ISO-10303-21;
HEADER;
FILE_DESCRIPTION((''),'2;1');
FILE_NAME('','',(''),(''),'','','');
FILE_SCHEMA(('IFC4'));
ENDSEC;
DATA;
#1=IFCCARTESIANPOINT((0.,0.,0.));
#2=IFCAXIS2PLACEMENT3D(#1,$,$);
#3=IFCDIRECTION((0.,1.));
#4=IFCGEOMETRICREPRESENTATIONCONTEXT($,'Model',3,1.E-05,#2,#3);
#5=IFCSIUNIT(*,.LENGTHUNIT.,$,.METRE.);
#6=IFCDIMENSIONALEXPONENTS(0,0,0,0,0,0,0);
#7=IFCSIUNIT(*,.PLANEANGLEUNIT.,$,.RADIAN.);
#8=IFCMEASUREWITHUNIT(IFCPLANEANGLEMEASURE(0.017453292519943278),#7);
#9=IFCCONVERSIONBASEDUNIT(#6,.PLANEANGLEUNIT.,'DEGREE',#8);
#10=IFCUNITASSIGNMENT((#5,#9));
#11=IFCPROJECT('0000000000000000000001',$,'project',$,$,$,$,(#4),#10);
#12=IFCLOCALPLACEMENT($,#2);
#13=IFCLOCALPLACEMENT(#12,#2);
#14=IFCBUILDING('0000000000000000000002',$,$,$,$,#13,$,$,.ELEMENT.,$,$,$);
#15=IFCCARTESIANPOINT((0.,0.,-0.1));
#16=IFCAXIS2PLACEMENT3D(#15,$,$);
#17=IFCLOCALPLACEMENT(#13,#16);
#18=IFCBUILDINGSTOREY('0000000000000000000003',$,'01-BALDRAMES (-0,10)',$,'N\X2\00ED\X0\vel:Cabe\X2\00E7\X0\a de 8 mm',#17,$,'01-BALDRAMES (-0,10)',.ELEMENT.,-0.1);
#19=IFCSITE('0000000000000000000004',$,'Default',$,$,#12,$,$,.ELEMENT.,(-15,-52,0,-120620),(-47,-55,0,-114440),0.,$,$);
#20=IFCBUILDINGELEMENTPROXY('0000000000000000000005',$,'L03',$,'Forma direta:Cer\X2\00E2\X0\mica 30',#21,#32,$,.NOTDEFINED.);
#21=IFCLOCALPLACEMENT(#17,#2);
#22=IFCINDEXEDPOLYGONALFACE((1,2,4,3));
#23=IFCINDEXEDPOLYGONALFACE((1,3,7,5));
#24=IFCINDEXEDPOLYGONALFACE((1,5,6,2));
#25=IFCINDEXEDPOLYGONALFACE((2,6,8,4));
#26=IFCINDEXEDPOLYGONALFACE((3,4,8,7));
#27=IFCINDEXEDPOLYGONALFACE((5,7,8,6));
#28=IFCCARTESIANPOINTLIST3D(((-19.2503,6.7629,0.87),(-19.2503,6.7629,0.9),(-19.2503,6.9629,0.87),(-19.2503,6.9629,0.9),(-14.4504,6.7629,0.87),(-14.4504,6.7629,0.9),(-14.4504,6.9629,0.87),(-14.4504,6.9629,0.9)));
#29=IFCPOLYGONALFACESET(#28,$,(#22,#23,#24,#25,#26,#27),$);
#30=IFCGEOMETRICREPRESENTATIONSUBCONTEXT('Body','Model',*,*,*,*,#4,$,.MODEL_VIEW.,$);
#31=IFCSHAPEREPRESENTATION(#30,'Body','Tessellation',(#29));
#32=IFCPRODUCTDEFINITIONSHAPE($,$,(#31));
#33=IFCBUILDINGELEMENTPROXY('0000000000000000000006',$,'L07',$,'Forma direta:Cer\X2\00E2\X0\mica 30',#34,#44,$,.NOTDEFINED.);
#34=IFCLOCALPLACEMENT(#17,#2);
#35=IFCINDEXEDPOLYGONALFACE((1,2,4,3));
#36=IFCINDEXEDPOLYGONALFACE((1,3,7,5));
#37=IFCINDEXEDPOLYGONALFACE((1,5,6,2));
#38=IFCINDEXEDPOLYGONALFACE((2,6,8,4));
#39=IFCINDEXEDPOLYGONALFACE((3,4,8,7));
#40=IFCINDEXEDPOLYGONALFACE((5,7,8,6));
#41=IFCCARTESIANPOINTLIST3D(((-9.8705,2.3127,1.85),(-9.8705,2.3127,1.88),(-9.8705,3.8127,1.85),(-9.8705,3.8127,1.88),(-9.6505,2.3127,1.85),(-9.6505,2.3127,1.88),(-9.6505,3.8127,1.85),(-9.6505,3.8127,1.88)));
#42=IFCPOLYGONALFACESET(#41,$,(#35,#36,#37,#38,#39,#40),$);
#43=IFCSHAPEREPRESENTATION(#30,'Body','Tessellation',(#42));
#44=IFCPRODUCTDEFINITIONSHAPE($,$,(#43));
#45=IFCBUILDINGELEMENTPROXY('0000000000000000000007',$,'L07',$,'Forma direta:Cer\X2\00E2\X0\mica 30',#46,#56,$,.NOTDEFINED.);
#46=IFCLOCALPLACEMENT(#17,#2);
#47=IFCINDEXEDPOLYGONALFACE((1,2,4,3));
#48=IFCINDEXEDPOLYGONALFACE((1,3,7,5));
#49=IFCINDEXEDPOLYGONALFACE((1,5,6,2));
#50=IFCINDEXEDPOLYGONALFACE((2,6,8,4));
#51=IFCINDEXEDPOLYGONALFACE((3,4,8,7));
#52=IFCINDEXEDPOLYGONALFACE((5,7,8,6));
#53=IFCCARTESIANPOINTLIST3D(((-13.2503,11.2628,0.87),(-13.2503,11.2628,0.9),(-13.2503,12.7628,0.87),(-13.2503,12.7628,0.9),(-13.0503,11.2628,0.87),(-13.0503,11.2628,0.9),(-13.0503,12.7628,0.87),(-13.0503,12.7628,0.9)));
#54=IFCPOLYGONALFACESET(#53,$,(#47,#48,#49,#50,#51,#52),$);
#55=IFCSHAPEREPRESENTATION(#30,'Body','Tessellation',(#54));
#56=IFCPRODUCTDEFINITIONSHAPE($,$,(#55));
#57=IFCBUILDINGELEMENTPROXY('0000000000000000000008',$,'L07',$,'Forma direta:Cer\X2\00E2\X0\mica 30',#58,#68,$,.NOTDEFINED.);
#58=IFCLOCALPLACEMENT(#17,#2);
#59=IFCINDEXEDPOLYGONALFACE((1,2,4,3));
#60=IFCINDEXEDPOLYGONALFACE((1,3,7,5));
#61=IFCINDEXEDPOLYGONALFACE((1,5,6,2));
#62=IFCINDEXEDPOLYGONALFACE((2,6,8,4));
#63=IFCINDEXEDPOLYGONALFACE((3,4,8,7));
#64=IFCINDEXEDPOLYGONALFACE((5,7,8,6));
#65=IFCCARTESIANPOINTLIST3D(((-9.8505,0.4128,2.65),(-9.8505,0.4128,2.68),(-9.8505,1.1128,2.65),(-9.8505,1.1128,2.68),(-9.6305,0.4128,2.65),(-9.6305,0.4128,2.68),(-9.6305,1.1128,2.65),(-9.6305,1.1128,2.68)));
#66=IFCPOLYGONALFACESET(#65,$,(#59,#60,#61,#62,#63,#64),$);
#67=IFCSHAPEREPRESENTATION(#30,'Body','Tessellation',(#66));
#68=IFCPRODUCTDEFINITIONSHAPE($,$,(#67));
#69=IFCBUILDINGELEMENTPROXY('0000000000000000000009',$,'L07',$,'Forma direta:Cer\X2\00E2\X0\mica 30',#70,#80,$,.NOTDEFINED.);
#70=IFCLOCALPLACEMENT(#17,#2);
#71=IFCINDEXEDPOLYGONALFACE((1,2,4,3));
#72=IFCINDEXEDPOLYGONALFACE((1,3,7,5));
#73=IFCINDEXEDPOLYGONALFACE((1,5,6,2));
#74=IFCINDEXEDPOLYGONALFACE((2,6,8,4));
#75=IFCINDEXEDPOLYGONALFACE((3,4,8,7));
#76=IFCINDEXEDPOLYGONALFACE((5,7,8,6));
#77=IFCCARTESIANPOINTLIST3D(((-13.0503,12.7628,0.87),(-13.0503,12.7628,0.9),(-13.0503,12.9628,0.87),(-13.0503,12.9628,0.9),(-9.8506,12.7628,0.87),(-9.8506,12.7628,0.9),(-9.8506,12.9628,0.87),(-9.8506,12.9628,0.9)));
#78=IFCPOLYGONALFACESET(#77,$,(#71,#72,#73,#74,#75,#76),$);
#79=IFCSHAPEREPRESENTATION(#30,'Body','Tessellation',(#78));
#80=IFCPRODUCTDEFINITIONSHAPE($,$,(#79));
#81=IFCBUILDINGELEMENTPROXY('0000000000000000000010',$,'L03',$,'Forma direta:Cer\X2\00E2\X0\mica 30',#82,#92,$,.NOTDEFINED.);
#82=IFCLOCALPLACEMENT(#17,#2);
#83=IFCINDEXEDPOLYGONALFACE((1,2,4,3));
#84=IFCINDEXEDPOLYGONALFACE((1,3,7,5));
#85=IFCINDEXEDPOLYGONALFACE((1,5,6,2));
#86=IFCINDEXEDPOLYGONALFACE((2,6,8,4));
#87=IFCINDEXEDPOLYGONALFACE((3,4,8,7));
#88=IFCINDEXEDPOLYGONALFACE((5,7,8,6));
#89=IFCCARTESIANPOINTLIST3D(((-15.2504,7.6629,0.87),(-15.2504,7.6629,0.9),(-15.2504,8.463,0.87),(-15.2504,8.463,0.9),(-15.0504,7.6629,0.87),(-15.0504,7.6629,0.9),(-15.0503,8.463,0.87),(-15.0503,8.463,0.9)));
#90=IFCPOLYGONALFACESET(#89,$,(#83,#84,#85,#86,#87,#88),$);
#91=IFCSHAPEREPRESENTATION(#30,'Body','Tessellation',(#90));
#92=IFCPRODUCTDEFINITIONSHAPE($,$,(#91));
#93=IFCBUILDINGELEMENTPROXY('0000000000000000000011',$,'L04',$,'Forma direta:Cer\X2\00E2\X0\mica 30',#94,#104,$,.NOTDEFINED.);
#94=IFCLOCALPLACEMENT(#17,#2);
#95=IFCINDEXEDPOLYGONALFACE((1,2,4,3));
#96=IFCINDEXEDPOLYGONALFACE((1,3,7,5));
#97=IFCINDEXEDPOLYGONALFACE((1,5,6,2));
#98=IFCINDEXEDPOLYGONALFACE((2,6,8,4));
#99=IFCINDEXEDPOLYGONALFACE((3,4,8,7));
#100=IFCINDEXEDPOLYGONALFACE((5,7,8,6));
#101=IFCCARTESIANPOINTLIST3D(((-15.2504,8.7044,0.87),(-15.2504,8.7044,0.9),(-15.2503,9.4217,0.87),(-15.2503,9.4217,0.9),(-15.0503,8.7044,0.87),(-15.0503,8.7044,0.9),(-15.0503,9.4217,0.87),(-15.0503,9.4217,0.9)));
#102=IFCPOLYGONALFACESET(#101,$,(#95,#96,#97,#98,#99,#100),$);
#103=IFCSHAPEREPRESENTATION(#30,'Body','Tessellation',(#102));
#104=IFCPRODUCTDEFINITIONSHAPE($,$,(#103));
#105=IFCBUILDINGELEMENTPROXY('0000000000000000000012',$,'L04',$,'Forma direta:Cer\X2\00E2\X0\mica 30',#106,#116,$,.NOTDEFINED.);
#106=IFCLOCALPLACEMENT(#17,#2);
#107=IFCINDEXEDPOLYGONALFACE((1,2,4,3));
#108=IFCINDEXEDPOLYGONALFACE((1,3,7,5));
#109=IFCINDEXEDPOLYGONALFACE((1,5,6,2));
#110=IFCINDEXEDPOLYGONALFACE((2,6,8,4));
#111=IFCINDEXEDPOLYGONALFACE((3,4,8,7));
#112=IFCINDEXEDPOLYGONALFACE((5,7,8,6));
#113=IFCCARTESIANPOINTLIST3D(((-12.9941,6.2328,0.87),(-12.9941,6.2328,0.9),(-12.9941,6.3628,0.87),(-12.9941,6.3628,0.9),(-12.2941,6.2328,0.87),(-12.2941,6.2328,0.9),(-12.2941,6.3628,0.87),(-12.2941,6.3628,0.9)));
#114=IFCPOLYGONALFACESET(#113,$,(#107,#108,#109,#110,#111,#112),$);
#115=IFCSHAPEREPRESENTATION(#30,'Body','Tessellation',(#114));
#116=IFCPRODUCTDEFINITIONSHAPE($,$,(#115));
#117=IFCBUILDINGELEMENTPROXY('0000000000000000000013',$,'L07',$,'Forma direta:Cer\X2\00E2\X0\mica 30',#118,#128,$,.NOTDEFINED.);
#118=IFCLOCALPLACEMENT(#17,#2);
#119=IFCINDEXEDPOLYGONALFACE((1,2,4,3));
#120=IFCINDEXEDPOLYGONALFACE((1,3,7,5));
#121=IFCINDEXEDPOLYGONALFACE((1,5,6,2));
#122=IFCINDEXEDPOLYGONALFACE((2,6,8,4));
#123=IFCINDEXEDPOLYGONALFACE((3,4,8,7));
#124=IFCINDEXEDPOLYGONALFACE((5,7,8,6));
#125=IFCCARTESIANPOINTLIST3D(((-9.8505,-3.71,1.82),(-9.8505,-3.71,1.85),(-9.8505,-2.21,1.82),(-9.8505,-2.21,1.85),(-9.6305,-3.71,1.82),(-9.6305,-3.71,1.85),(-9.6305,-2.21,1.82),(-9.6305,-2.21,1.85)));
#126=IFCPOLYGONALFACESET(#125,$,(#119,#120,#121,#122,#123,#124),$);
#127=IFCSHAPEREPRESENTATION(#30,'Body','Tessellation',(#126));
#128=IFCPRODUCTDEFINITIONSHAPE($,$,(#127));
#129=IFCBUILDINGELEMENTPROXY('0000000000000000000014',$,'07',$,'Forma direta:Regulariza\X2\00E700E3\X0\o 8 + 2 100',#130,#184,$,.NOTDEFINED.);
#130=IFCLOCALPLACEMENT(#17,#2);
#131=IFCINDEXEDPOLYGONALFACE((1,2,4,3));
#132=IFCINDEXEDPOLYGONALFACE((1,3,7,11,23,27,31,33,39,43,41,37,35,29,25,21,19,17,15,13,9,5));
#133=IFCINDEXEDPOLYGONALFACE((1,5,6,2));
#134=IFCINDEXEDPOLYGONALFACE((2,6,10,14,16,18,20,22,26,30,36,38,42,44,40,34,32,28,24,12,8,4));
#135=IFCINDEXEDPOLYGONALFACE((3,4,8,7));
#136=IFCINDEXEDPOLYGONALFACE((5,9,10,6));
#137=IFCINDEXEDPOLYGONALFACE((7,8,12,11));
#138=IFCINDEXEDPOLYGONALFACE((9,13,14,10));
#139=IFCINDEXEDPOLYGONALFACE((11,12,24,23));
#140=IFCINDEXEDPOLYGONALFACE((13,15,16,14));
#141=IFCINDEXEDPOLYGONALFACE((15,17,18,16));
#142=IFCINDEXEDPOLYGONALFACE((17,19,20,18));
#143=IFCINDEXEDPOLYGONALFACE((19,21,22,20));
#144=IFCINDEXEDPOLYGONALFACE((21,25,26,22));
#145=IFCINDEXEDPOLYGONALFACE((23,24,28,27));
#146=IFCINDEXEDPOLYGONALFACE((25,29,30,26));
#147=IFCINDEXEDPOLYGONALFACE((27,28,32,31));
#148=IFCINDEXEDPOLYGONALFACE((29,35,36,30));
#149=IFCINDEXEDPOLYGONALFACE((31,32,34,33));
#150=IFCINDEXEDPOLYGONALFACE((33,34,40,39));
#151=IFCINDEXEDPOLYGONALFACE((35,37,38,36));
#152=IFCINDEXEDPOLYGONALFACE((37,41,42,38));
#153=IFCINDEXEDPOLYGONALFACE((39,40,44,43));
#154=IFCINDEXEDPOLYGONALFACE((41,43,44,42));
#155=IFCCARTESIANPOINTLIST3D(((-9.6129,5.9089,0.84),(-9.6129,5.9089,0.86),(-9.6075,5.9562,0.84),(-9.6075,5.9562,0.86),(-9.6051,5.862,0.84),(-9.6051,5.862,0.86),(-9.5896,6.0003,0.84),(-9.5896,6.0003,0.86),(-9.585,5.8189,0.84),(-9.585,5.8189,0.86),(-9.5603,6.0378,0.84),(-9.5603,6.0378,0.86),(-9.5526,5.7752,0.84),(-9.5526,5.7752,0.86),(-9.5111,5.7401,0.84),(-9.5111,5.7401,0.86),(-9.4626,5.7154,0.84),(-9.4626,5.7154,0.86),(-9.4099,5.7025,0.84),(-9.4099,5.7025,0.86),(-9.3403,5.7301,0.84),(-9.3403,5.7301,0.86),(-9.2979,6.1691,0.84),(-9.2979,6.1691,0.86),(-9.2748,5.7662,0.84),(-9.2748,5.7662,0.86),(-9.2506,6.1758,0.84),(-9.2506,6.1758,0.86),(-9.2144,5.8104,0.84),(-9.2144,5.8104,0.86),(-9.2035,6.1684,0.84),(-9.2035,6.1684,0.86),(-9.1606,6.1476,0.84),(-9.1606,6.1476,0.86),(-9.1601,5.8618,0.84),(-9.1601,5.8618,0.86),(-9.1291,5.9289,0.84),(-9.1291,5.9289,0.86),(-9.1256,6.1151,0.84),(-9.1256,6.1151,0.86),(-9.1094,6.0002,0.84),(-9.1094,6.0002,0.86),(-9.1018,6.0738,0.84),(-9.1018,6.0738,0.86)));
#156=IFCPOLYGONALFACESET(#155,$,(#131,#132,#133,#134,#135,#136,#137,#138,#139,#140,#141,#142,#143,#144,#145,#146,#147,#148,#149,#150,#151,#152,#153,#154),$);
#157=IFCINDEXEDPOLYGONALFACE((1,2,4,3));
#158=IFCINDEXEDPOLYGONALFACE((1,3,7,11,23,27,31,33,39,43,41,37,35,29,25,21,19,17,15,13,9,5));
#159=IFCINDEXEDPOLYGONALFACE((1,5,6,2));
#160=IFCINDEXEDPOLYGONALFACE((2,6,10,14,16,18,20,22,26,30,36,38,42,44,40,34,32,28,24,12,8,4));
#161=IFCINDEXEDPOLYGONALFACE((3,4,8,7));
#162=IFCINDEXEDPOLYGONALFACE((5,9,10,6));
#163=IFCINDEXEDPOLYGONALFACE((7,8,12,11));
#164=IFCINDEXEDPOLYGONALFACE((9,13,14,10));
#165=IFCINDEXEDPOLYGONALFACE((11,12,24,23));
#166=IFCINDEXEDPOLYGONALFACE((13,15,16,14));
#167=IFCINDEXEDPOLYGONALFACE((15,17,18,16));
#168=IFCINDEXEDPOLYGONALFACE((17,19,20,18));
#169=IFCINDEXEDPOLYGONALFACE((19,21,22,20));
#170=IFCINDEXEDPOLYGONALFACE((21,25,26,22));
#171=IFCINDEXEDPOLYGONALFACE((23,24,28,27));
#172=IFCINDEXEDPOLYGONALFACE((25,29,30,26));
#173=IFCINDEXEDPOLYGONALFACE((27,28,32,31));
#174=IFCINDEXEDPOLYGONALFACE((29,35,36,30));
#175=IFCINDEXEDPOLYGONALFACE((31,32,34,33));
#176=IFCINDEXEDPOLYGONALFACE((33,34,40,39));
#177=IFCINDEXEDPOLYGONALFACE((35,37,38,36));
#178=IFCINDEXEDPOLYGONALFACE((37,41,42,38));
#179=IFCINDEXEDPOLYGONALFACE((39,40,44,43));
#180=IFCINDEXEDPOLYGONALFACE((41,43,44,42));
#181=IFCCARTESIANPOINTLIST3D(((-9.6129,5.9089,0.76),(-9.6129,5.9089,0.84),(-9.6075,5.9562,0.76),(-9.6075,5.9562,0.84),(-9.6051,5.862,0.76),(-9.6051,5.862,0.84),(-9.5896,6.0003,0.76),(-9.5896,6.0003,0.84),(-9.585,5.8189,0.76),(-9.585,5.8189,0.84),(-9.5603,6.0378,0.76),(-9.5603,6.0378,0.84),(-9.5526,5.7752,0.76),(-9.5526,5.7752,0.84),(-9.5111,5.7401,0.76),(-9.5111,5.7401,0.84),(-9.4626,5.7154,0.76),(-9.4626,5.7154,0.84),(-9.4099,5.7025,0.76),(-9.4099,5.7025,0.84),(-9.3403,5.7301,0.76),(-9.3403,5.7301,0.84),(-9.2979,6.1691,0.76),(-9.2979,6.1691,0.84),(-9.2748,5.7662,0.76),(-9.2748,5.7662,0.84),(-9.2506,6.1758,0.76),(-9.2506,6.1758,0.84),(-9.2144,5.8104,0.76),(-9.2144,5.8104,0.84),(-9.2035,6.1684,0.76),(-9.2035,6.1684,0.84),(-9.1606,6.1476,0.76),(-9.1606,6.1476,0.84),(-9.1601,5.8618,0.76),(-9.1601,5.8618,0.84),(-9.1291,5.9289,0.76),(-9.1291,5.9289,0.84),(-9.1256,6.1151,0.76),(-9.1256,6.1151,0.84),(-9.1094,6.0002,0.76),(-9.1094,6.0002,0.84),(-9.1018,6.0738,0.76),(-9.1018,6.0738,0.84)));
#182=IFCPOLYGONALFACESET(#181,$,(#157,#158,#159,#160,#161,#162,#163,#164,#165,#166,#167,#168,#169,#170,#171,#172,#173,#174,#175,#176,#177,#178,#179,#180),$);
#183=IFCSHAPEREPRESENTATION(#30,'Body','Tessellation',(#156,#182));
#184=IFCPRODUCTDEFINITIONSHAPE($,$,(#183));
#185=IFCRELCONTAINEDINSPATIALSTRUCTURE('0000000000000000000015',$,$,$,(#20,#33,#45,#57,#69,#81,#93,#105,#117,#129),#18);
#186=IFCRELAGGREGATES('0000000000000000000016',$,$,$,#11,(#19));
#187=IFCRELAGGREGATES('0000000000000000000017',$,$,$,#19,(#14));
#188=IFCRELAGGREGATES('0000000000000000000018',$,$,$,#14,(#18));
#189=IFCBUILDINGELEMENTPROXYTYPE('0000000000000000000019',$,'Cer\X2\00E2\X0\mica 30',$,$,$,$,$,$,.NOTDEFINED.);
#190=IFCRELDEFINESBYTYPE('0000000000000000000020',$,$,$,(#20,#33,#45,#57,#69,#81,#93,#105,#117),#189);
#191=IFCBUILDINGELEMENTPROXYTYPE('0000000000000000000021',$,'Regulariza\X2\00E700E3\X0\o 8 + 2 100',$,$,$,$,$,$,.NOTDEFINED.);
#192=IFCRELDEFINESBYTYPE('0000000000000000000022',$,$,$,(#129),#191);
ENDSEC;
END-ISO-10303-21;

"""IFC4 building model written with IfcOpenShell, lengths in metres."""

from ifc_helpers import new_model, entity, si_unit, converted_unit, direction, frame, origin, place, context, subcontext, project, spatial, line, arc, indexed_curve, outline, extrude, type_object, element, save


model = new_model("IFC4")

# Units and contexts
model_context = context("Model", 3, precision=1e-05, world=origin(), true_north=direction((0.0, 1.0)))
body_context = subcontext(model_context, "Body", "Model", "MODEL_VIEW")
ifc_project = project(units=[si_unit("LENGTHUNIT", "METRE"), converted_unit("PLANEANGLEUNIT", "DEGREE", entity("IfcPlaneAngleMeasure", 0.017453292519943278), si_unit("PLANEANGLEUNIT", "RADIAN"), dimensions=[0, 0, 0, 0, 0, 0, 0])], contexts=[model_context])

# Site, building, storey
site_placement = place(None, origin())
site = spatial("IfcSite", under=ifc_project, at=site_placement, Name="Default", CompositionType="ELEMENT", RefLatitude=(-15, -52, 0, -120620), RefLongitude=(-47, -55, 0, -114440), RefElevation=0.0)
building_placement = place(site_placement, origin())
building = spatial("IfcBuilding", under=site, at=building_placement, CompositionType="ELEMENT")
storey_placement = place(building_placement, frame((0.0, 0.0, -0.1)))
storey = spatial("IfcBuildingStorey", under=building, at=storey_placement, Name="01-BALDRAMES (-0,10)", ObjectType="Nível:Cabeça de 8 mm", LongName="01-BALDRAMES (-0,10)", CompositionType="ELEMENT", Elevation=-0.1)

# Building element proxies
building_element_proxy_type_1 = type_object("IfcBuildingElementProxyType", Name="Cerâmica 30", PredefinedType="NOTDEFINED")
proxy_1_placement = place(storey_placement, origin())
element("IfcBuildingElementProxy", 1, at=proxy_1_placement, inside=storey, type_object=building_element_proxy_type_1, Name="L03", ObjectType="Forma direta:Cerâmica 30", PredefinedType="NOTDEFINED", context=body_context, shape_type="SweptSolid", body=[
    extrude(outline(indexed_curve([(-2.4, -0.1), (2.4, -0.1), (2.4, 0.1), (-2.4, 0.1), (-2.4, -0.1)], self_intersect=False)), frame((-16.8503, 6.8629, 0.87)), (0.0, 0.0, 1.0), 0.03),
])
proxy_2_placement = place(storey_placement, origin())
element("IfcBuildingElementProxy", 2, at=proxy_2_placement, inside=storey, type_object=building_element_proxy_type_1, Name="L07", ObjectType="Forma direta:Cerâmica 30", PredefinedType="NOTDEFINED", context=body_context, shape_type="SweptSolid", body=[
    extrude(outline(indexed_curve([(-0.75, -0.11), (0.75, -0.11), (0.75, 0.11), (-0.75, 0.11), (-0.75, -0.11)], self_intersect=False)), frame((-9.7605, 3.0627, 1.85), z_axis=(0.0, 0.0, 1.0), x_axis=(-0.000006, 1.0, 0.0)), (0.0, 0.0, 1.0), 0.03),
])
proxy_3_placement = place(storey_placement, origin())
element("IfcBuildingElementProxy", 3, at=proxy_3_placement, inside=storey, type_object=building_element_proxy_type_1, Name="L07", ObjectType="Forma direta:Cerâmica 30", PredefinedType="NOTDEFINED", context=body_context, shape_type="SweptSolid", body=[
    extrude(outline(indexed_curve([(-0.75, -0.1), (0.75, -0.1), (0.75, 0.1), (-0.75, 0.1), (-0.75, -0.1)], self_intersect=False)), frame((-13.1503, 12.0128, 0.87), z_axis=(0.0, 0.0, 1.0), x_axis=(-0.000013, -1.0, 0.0)), (0.0, 0.0, 1.0), 0.03),
])
proxy_4_placement = place(storey_placement, origin())
element("IfcBuildingElementProxy", 4, at=proxy_4_placement, inside=storey, type_object=building_element_proxy_type_1, Name="L07", ObjectType="Forma direta:Cerâmica 30", PredefinedType="NOTDEFINED", context=body_context, shape_type="SweptSolid", body=[
    extrude(outline(indexed_curve([(-0.35, -0.11), (0.35, -0.11), (0.35, 0.11), (-0.35, 0.11), (-0.35, -0.11)], self_intersect=False)), frame((-9.7405, 0.7628, 2.65), z_axis=(0.0, 0.0, 1.0), x_axis=(-0.000006, 1.0, 0.0)), (0.0, 0.0, 1.0), 0.03),
])
proxy_5_placement = place(storey_placement, origin())
element("IfcBuildingElementProxy", 5, at=proxy_5_placement, inside=storey, type_object=building_element_proxy_type_1, Name="L07", ObjectType="Forma direta:Cerâmica 30", PredefinedType="NOTDEFINED", context=body_context, shape_type="SweptSolid", body=[
    extrude(outline(indexed_curve([(-1.5999, -0.1), (1.5999, -0.1), (1.5999, 0.1), (-1.5999, 0.1), (-1.5999, -0.1)], self_intersect=False)), frame((-11.4504, 12.8628, 0.87)), (0.0, 0.0, 1.0), 0.03),
])
proxy_6_placement = place(storey_placement, origin())
element("IfcBuildingElementProxy", 6, at=proxy_6_placement, inside=storey, type_object=building_element_proxy_type_1, Name="L03", ObjectType="Forma direta:Cerâmica 30", PredefinedType="NOTDEFINED", context=body_context, shape_type="SweptSolid", body=[
    extrude(outline(indexed_curve([(-0.4001, -0.1), (0.4001, -0.1), (0.4001, 0.1), (-0.4001, 0.1), (-0.4001, -0.1)], self_intersect=False)), frame((-15.1504, 8.0629, 0.87), z_axis=(0.0, 0.0, 1.0), x_axis=(0.000013, 1.0, 0.0)), (0.0, 0.0, 1.0), 0.03),
])
proxy_7_placement = place(storey_placement, origin())
element("IfcBuildingElementProxy", 7, at=proxy_7_placement, inside=storey, type_object=building_element_proxy_type_1, Name="L04", ObjectType="Forma direta:Cerâmica 30", PredefinedType="NOTDEFINED", context=body_context, shape_type="SweptSolid", body=[
    extrude(outline(indexed_curve([(-0.3587, -0.1), (0.3587, -0.1), (0.3587, 0.1), (-0.3587, 0.1), (-0.3587, -0.1)], self_intersect=False)), frame((-15.1503, 9.063, 0.87), z_axis=(0.0, 0.0, 1.0), x_axis=(0.000013, 1.0, 0.0)), (0.0, 0.0, 1.0), 0.03),
])
proxy_8_placement = place(storey_placement, origin())
element("IfcBuildingElementProxy", 8, at=proxy_8_placement, inside=storey, type_object=building_element_proxy_type_1, Name="L04", ObjectType="Forma direta:Cerâmica 30", PredefinedType="NOTDEFINED", context=body_context, shape_type="SweptSolid", body=[
    extrude(outline(indexed_curve([(-0.35, -0.065), (0.35, -0.065), (0.35, 0.065), (-0.35, 0.065), (-0.35, -0.065)], self_intersect=False)), frame((-12.6441, 6.2978, 0.87)), (0.0, 0.0, 1.0), 0.03),
])
proxy_9_placement = place(storey_placement, origin())
element("IfcBuildingElementProxy", 9, at=proxy_9_placement, inside=storey, type_object=building_element_proxy_type_1, Name="L07", ObjectType="Forma direta:Cerâmica 30", PredefinedType="NOTDEFINED", context=body_context, shape_type="SweptSolid", body=[
    extrude(outline(indexed_curve([(-0.75, -0.11), (0.75, -0.11), (0.75, 0.11), (-0.75, 0.11), (-0.75, -0.11)], self_intersect=False)), frame((-9.7405, -2.96, 1.82), z_axis=(0.0, 0.0, 1.0), x_axis=(-0.000006, 1.0, 0.0)), (0.0, 0.0, 1.0), 0.03),
])
building_element_proxy_type_2 = type_object("IfcBuildingElementProxyType", Name="Regularização 8 + 2 100", PredefinedType="NOTDEFINED")
proxy_10_placement = place(storey_placement, origin())
element("IfcBuildingElementProxy", 10, at=proxy_10_placement, inside=storey, type_object=building_element_proxy_type_2, Name="07", ObjectType="Forma direta:Regularização 8 + 2 100", PredefinedType="NOTDEFINED", context=body_context, shape_type="SweptSolid", body=[
    extrude(outline(indexed_curve([(0.2639, -0.0077), (0.2392, 0.0974), (0.1703, 0.1806), (0.0215, 0.1928), (-0.1256, 0.1673), (-0.2134, 0.0997), (-0.2821, 0.0127), (-0.256, -0.1013), (-0.1597, -0.1677), (0.1332, -0.1851), (0.2303, -0.1198)], segments=[arc(1, 2, 3), arc(3, 4, 5), arc(5, 6, 7), arc(7, 8, 9), line(9, 10), arc(10, 11, 1)], self_intersect=False)), frame((-9.3525, 5.944, 0.84), z_axis=(0.0, 0.0, 1.0), x_axis=(-0.866401, -0.499349, 0.0)), (0.0, 0.0, 1.0), 0.02),
    extrude(outline(indexed_curve([(0.2639, -0.0077), (0.2392, 0.0974), (0.1703, 0.1806), (0.0215, 0.1928), (-0.1256, 0.1673), (-0.2134, 0.0997), (-0.2821, 0.0127), (-0.256, -0.1013), (-0.1597, -0.1677), (0.1332, -0.1851), (0.2303, -0.1198)], segments=[arc(1, 2, 3), arc(3, 4, 5), arc(5, 6, 7), arc(7, 8, 9), line(9, 10), arc(10, 11, 1)], self_intersect=False)), frame((-9.3525, 5.944, 0.76), z_axis=(0.0, 0.0, 1.0), x_axis=(-0.866401, -0.499349, 0.0)), (0.0, 0.0, 1.0), 0.08),
])

save(model, "model.ifc")
